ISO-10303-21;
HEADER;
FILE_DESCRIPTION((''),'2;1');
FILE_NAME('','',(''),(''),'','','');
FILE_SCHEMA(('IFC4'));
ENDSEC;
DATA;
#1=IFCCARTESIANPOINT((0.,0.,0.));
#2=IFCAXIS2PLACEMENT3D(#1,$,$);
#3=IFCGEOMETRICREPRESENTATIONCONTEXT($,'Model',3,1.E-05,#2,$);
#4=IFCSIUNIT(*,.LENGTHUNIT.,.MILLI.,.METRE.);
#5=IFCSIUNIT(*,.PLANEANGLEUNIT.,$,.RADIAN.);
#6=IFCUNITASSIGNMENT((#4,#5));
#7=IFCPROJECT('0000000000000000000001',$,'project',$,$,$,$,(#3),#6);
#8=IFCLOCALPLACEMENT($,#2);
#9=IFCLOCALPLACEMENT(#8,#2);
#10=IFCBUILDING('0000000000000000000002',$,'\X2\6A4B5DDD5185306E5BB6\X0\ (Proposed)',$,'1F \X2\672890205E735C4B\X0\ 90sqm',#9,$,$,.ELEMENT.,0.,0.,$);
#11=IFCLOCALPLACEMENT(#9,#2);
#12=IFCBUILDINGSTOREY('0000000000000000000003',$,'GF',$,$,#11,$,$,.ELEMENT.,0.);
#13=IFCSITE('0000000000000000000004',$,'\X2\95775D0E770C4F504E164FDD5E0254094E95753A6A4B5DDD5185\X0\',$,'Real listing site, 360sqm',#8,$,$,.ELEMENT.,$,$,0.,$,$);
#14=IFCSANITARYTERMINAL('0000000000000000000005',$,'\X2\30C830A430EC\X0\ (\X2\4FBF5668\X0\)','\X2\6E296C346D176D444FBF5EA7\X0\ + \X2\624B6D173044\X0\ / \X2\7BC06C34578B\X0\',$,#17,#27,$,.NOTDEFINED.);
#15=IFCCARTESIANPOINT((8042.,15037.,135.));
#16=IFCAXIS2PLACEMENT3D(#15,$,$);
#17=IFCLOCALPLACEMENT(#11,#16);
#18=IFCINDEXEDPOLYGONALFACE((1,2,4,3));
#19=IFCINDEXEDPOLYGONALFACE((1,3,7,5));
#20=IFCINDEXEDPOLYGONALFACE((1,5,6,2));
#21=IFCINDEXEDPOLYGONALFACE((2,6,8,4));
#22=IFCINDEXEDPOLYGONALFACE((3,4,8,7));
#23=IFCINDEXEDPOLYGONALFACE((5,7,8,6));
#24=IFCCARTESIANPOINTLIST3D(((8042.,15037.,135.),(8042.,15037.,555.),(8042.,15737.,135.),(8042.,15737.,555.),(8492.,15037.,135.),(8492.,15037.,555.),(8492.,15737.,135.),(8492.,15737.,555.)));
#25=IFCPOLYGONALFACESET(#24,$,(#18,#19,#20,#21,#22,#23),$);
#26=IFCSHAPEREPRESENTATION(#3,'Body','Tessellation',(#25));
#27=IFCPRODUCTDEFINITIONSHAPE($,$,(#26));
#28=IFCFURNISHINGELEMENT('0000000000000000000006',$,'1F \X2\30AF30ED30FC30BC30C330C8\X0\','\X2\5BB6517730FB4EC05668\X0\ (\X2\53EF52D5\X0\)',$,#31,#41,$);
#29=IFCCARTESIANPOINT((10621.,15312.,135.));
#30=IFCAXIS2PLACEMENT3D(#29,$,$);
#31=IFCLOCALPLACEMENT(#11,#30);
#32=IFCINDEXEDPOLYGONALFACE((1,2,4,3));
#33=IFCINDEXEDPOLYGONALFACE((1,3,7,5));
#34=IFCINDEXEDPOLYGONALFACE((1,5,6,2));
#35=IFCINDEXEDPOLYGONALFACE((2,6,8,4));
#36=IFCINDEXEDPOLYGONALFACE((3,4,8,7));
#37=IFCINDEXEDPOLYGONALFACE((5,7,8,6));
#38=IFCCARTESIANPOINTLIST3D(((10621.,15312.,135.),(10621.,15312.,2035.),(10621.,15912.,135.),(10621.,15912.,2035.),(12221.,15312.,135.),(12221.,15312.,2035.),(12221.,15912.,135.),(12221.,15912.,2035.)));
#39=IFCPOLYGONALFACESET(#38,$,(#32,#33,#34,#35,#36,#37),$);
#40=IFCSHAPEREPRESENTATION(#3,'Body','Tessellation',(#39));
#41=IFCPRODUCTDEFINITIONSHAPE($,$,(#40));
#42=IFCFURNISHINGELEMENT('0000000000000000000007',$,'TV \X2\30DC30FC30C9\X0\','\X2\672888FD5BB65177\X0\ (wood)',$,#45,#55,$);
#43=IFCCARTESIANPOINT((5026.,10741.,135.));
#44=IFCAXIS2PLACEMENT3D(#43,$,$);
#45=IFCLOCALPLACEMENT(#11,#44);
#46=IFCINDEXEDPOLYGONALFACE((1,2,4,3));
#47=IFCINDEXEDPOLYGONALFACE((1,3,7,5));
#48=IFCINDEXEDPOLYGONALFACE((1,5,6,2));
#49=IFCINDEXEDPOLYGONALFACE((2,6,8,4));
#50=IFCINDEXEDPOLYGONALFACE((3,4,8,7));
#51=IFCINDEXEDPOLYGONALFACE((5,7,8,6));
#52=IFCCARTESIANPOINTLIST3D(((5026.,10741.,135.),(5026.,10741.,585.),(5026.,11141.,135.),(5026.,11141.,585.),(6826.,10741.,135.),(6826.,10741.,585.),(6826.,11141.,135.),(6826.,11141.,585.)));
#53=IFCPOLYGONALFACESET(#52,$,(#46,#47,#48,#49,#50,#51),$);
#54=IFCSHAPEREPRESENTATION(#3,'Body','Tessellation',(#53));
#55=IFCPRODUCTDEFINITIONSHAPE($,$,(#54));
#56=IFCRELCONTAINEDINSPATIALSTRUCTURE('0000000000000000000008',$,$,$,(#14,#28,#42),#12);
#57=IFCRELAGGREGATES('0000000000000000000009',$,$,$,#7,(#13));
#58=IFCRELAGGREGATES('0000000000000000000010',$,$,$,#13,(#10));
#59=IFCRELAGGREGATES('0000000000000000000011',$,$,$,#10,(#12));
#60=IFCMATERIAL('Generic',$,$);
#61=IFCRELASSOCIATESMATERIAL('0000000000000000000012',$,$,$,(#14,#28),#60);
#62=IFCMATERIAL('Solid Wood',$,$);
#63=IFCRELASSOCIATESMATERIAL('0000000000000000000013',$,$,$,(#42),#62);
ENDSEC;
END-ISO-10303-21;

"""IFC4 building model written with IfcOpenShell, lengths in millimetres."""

from ifc_helpers import new_model, si_unit, frame, frame_2d, origin, place, context, project, spatial, rectangle, extrude, material, element, save


model = new_model("IFC4")

# Units and contexts
model_context = context("Model", 3, precision=1e-05, world=origin())
ifc_project = project(units=[si_unit("LENGTHUNIT", "METRE", prefix="MILLI"), si_unit("PLANEANGLEUNIT", "RADIAN")], contexts=[model_context])

# Site, building, storey
site_placement = place(None, origin())
site = spatial("IfcSite", under=ifc_project, at=site_placement, Name="長崎県佐世保市吉井町橋川内", ObjectType="Real listing site, 360sqm", CompositionType="ELEMENT", RefElevation=0.0)
building_placement = place(site_placement, origin())
building = spatial("IfcBuilding", under=site, at=building_placement, Name="橋川内の家 (Proposed)", ObjectType="1F 木造平屋 90sqm", CompositionType="ELEMENT", ElevationOfRefHeight=0.0, ElevationOfTerrain=0.0)
storey_placement = place(building_placement, origin())
storey = spatial("IfcBuildingStorey", under=building, at=storey_placement, Name="GF", CompositionType="ELEMENT", Elevation=0.0)

# Shared definitions
ifc_material_1 = material(Name="Solid Wood")

# Sanitary terminal
ifc_material_2 = material(Name="Generic")
sanitary_terminal_1_placement = place(storey_placement, frame((8042.0, 15037.0, 135.0)))
element("IfcSanitaryTerminal", 1, at=sanitary_terminal_1_placement, inside=storey, material=ifc_material_2, Name="トイレ (便器)", Description="温水洗浄便座 + 手洗い / 節水型", PredefinedType="NOTDEFINED", context=model_context, shape_type="SweptSolid", body=[
    extrude(rectangle(XDim=450.0, YDim=700.0, at=frame_2d((225.0, 350.0))), frame((8042.0, 15037.0, 135.0)), (0.0, 0.0, 1.0), 420.0),
])

# Furnishing elements
furnishing_1_placement = place(storey_placement, frame((10621.0, 15312.0, 135.0)))
element("IfcFurnishingElement", 2, at=furnishing_1_placement, inside=storey, material=ifc_material_2, Name="1F クローゼット", Description="家具・什器 (可動)", context=model_context, shape_type="SweptSolid", body=[
    extrude(rectangle(XDim=1600.0, YDim=600.0, at=frame_2d((800.0, 300.0))), frame((10621.0, 15312.0, 135.0)), (0.0, 0.0, 1.0), 1900.0),
])
furnishing_2_placement = place(storey_placement, frame((5026.0, 10741.0, 135.0)))
element("IfcFurnishingElement", 3, at=furnishing_2_placement, inside=storey, material=ifc_material_1, Name="TV ボード", Description="木製家具 (wood)", context=model_context, shape_type="SweptSolid", body=[
    extrude(rectangle(XDim=1800.0, YDim=400.0, at=frame_2d((900.0, 200.0))), frame((5026.0, 10741.0, 135.0)), (0.0, 0.0, 1.0), 450.0),
])

save(model, "model.ifc")
